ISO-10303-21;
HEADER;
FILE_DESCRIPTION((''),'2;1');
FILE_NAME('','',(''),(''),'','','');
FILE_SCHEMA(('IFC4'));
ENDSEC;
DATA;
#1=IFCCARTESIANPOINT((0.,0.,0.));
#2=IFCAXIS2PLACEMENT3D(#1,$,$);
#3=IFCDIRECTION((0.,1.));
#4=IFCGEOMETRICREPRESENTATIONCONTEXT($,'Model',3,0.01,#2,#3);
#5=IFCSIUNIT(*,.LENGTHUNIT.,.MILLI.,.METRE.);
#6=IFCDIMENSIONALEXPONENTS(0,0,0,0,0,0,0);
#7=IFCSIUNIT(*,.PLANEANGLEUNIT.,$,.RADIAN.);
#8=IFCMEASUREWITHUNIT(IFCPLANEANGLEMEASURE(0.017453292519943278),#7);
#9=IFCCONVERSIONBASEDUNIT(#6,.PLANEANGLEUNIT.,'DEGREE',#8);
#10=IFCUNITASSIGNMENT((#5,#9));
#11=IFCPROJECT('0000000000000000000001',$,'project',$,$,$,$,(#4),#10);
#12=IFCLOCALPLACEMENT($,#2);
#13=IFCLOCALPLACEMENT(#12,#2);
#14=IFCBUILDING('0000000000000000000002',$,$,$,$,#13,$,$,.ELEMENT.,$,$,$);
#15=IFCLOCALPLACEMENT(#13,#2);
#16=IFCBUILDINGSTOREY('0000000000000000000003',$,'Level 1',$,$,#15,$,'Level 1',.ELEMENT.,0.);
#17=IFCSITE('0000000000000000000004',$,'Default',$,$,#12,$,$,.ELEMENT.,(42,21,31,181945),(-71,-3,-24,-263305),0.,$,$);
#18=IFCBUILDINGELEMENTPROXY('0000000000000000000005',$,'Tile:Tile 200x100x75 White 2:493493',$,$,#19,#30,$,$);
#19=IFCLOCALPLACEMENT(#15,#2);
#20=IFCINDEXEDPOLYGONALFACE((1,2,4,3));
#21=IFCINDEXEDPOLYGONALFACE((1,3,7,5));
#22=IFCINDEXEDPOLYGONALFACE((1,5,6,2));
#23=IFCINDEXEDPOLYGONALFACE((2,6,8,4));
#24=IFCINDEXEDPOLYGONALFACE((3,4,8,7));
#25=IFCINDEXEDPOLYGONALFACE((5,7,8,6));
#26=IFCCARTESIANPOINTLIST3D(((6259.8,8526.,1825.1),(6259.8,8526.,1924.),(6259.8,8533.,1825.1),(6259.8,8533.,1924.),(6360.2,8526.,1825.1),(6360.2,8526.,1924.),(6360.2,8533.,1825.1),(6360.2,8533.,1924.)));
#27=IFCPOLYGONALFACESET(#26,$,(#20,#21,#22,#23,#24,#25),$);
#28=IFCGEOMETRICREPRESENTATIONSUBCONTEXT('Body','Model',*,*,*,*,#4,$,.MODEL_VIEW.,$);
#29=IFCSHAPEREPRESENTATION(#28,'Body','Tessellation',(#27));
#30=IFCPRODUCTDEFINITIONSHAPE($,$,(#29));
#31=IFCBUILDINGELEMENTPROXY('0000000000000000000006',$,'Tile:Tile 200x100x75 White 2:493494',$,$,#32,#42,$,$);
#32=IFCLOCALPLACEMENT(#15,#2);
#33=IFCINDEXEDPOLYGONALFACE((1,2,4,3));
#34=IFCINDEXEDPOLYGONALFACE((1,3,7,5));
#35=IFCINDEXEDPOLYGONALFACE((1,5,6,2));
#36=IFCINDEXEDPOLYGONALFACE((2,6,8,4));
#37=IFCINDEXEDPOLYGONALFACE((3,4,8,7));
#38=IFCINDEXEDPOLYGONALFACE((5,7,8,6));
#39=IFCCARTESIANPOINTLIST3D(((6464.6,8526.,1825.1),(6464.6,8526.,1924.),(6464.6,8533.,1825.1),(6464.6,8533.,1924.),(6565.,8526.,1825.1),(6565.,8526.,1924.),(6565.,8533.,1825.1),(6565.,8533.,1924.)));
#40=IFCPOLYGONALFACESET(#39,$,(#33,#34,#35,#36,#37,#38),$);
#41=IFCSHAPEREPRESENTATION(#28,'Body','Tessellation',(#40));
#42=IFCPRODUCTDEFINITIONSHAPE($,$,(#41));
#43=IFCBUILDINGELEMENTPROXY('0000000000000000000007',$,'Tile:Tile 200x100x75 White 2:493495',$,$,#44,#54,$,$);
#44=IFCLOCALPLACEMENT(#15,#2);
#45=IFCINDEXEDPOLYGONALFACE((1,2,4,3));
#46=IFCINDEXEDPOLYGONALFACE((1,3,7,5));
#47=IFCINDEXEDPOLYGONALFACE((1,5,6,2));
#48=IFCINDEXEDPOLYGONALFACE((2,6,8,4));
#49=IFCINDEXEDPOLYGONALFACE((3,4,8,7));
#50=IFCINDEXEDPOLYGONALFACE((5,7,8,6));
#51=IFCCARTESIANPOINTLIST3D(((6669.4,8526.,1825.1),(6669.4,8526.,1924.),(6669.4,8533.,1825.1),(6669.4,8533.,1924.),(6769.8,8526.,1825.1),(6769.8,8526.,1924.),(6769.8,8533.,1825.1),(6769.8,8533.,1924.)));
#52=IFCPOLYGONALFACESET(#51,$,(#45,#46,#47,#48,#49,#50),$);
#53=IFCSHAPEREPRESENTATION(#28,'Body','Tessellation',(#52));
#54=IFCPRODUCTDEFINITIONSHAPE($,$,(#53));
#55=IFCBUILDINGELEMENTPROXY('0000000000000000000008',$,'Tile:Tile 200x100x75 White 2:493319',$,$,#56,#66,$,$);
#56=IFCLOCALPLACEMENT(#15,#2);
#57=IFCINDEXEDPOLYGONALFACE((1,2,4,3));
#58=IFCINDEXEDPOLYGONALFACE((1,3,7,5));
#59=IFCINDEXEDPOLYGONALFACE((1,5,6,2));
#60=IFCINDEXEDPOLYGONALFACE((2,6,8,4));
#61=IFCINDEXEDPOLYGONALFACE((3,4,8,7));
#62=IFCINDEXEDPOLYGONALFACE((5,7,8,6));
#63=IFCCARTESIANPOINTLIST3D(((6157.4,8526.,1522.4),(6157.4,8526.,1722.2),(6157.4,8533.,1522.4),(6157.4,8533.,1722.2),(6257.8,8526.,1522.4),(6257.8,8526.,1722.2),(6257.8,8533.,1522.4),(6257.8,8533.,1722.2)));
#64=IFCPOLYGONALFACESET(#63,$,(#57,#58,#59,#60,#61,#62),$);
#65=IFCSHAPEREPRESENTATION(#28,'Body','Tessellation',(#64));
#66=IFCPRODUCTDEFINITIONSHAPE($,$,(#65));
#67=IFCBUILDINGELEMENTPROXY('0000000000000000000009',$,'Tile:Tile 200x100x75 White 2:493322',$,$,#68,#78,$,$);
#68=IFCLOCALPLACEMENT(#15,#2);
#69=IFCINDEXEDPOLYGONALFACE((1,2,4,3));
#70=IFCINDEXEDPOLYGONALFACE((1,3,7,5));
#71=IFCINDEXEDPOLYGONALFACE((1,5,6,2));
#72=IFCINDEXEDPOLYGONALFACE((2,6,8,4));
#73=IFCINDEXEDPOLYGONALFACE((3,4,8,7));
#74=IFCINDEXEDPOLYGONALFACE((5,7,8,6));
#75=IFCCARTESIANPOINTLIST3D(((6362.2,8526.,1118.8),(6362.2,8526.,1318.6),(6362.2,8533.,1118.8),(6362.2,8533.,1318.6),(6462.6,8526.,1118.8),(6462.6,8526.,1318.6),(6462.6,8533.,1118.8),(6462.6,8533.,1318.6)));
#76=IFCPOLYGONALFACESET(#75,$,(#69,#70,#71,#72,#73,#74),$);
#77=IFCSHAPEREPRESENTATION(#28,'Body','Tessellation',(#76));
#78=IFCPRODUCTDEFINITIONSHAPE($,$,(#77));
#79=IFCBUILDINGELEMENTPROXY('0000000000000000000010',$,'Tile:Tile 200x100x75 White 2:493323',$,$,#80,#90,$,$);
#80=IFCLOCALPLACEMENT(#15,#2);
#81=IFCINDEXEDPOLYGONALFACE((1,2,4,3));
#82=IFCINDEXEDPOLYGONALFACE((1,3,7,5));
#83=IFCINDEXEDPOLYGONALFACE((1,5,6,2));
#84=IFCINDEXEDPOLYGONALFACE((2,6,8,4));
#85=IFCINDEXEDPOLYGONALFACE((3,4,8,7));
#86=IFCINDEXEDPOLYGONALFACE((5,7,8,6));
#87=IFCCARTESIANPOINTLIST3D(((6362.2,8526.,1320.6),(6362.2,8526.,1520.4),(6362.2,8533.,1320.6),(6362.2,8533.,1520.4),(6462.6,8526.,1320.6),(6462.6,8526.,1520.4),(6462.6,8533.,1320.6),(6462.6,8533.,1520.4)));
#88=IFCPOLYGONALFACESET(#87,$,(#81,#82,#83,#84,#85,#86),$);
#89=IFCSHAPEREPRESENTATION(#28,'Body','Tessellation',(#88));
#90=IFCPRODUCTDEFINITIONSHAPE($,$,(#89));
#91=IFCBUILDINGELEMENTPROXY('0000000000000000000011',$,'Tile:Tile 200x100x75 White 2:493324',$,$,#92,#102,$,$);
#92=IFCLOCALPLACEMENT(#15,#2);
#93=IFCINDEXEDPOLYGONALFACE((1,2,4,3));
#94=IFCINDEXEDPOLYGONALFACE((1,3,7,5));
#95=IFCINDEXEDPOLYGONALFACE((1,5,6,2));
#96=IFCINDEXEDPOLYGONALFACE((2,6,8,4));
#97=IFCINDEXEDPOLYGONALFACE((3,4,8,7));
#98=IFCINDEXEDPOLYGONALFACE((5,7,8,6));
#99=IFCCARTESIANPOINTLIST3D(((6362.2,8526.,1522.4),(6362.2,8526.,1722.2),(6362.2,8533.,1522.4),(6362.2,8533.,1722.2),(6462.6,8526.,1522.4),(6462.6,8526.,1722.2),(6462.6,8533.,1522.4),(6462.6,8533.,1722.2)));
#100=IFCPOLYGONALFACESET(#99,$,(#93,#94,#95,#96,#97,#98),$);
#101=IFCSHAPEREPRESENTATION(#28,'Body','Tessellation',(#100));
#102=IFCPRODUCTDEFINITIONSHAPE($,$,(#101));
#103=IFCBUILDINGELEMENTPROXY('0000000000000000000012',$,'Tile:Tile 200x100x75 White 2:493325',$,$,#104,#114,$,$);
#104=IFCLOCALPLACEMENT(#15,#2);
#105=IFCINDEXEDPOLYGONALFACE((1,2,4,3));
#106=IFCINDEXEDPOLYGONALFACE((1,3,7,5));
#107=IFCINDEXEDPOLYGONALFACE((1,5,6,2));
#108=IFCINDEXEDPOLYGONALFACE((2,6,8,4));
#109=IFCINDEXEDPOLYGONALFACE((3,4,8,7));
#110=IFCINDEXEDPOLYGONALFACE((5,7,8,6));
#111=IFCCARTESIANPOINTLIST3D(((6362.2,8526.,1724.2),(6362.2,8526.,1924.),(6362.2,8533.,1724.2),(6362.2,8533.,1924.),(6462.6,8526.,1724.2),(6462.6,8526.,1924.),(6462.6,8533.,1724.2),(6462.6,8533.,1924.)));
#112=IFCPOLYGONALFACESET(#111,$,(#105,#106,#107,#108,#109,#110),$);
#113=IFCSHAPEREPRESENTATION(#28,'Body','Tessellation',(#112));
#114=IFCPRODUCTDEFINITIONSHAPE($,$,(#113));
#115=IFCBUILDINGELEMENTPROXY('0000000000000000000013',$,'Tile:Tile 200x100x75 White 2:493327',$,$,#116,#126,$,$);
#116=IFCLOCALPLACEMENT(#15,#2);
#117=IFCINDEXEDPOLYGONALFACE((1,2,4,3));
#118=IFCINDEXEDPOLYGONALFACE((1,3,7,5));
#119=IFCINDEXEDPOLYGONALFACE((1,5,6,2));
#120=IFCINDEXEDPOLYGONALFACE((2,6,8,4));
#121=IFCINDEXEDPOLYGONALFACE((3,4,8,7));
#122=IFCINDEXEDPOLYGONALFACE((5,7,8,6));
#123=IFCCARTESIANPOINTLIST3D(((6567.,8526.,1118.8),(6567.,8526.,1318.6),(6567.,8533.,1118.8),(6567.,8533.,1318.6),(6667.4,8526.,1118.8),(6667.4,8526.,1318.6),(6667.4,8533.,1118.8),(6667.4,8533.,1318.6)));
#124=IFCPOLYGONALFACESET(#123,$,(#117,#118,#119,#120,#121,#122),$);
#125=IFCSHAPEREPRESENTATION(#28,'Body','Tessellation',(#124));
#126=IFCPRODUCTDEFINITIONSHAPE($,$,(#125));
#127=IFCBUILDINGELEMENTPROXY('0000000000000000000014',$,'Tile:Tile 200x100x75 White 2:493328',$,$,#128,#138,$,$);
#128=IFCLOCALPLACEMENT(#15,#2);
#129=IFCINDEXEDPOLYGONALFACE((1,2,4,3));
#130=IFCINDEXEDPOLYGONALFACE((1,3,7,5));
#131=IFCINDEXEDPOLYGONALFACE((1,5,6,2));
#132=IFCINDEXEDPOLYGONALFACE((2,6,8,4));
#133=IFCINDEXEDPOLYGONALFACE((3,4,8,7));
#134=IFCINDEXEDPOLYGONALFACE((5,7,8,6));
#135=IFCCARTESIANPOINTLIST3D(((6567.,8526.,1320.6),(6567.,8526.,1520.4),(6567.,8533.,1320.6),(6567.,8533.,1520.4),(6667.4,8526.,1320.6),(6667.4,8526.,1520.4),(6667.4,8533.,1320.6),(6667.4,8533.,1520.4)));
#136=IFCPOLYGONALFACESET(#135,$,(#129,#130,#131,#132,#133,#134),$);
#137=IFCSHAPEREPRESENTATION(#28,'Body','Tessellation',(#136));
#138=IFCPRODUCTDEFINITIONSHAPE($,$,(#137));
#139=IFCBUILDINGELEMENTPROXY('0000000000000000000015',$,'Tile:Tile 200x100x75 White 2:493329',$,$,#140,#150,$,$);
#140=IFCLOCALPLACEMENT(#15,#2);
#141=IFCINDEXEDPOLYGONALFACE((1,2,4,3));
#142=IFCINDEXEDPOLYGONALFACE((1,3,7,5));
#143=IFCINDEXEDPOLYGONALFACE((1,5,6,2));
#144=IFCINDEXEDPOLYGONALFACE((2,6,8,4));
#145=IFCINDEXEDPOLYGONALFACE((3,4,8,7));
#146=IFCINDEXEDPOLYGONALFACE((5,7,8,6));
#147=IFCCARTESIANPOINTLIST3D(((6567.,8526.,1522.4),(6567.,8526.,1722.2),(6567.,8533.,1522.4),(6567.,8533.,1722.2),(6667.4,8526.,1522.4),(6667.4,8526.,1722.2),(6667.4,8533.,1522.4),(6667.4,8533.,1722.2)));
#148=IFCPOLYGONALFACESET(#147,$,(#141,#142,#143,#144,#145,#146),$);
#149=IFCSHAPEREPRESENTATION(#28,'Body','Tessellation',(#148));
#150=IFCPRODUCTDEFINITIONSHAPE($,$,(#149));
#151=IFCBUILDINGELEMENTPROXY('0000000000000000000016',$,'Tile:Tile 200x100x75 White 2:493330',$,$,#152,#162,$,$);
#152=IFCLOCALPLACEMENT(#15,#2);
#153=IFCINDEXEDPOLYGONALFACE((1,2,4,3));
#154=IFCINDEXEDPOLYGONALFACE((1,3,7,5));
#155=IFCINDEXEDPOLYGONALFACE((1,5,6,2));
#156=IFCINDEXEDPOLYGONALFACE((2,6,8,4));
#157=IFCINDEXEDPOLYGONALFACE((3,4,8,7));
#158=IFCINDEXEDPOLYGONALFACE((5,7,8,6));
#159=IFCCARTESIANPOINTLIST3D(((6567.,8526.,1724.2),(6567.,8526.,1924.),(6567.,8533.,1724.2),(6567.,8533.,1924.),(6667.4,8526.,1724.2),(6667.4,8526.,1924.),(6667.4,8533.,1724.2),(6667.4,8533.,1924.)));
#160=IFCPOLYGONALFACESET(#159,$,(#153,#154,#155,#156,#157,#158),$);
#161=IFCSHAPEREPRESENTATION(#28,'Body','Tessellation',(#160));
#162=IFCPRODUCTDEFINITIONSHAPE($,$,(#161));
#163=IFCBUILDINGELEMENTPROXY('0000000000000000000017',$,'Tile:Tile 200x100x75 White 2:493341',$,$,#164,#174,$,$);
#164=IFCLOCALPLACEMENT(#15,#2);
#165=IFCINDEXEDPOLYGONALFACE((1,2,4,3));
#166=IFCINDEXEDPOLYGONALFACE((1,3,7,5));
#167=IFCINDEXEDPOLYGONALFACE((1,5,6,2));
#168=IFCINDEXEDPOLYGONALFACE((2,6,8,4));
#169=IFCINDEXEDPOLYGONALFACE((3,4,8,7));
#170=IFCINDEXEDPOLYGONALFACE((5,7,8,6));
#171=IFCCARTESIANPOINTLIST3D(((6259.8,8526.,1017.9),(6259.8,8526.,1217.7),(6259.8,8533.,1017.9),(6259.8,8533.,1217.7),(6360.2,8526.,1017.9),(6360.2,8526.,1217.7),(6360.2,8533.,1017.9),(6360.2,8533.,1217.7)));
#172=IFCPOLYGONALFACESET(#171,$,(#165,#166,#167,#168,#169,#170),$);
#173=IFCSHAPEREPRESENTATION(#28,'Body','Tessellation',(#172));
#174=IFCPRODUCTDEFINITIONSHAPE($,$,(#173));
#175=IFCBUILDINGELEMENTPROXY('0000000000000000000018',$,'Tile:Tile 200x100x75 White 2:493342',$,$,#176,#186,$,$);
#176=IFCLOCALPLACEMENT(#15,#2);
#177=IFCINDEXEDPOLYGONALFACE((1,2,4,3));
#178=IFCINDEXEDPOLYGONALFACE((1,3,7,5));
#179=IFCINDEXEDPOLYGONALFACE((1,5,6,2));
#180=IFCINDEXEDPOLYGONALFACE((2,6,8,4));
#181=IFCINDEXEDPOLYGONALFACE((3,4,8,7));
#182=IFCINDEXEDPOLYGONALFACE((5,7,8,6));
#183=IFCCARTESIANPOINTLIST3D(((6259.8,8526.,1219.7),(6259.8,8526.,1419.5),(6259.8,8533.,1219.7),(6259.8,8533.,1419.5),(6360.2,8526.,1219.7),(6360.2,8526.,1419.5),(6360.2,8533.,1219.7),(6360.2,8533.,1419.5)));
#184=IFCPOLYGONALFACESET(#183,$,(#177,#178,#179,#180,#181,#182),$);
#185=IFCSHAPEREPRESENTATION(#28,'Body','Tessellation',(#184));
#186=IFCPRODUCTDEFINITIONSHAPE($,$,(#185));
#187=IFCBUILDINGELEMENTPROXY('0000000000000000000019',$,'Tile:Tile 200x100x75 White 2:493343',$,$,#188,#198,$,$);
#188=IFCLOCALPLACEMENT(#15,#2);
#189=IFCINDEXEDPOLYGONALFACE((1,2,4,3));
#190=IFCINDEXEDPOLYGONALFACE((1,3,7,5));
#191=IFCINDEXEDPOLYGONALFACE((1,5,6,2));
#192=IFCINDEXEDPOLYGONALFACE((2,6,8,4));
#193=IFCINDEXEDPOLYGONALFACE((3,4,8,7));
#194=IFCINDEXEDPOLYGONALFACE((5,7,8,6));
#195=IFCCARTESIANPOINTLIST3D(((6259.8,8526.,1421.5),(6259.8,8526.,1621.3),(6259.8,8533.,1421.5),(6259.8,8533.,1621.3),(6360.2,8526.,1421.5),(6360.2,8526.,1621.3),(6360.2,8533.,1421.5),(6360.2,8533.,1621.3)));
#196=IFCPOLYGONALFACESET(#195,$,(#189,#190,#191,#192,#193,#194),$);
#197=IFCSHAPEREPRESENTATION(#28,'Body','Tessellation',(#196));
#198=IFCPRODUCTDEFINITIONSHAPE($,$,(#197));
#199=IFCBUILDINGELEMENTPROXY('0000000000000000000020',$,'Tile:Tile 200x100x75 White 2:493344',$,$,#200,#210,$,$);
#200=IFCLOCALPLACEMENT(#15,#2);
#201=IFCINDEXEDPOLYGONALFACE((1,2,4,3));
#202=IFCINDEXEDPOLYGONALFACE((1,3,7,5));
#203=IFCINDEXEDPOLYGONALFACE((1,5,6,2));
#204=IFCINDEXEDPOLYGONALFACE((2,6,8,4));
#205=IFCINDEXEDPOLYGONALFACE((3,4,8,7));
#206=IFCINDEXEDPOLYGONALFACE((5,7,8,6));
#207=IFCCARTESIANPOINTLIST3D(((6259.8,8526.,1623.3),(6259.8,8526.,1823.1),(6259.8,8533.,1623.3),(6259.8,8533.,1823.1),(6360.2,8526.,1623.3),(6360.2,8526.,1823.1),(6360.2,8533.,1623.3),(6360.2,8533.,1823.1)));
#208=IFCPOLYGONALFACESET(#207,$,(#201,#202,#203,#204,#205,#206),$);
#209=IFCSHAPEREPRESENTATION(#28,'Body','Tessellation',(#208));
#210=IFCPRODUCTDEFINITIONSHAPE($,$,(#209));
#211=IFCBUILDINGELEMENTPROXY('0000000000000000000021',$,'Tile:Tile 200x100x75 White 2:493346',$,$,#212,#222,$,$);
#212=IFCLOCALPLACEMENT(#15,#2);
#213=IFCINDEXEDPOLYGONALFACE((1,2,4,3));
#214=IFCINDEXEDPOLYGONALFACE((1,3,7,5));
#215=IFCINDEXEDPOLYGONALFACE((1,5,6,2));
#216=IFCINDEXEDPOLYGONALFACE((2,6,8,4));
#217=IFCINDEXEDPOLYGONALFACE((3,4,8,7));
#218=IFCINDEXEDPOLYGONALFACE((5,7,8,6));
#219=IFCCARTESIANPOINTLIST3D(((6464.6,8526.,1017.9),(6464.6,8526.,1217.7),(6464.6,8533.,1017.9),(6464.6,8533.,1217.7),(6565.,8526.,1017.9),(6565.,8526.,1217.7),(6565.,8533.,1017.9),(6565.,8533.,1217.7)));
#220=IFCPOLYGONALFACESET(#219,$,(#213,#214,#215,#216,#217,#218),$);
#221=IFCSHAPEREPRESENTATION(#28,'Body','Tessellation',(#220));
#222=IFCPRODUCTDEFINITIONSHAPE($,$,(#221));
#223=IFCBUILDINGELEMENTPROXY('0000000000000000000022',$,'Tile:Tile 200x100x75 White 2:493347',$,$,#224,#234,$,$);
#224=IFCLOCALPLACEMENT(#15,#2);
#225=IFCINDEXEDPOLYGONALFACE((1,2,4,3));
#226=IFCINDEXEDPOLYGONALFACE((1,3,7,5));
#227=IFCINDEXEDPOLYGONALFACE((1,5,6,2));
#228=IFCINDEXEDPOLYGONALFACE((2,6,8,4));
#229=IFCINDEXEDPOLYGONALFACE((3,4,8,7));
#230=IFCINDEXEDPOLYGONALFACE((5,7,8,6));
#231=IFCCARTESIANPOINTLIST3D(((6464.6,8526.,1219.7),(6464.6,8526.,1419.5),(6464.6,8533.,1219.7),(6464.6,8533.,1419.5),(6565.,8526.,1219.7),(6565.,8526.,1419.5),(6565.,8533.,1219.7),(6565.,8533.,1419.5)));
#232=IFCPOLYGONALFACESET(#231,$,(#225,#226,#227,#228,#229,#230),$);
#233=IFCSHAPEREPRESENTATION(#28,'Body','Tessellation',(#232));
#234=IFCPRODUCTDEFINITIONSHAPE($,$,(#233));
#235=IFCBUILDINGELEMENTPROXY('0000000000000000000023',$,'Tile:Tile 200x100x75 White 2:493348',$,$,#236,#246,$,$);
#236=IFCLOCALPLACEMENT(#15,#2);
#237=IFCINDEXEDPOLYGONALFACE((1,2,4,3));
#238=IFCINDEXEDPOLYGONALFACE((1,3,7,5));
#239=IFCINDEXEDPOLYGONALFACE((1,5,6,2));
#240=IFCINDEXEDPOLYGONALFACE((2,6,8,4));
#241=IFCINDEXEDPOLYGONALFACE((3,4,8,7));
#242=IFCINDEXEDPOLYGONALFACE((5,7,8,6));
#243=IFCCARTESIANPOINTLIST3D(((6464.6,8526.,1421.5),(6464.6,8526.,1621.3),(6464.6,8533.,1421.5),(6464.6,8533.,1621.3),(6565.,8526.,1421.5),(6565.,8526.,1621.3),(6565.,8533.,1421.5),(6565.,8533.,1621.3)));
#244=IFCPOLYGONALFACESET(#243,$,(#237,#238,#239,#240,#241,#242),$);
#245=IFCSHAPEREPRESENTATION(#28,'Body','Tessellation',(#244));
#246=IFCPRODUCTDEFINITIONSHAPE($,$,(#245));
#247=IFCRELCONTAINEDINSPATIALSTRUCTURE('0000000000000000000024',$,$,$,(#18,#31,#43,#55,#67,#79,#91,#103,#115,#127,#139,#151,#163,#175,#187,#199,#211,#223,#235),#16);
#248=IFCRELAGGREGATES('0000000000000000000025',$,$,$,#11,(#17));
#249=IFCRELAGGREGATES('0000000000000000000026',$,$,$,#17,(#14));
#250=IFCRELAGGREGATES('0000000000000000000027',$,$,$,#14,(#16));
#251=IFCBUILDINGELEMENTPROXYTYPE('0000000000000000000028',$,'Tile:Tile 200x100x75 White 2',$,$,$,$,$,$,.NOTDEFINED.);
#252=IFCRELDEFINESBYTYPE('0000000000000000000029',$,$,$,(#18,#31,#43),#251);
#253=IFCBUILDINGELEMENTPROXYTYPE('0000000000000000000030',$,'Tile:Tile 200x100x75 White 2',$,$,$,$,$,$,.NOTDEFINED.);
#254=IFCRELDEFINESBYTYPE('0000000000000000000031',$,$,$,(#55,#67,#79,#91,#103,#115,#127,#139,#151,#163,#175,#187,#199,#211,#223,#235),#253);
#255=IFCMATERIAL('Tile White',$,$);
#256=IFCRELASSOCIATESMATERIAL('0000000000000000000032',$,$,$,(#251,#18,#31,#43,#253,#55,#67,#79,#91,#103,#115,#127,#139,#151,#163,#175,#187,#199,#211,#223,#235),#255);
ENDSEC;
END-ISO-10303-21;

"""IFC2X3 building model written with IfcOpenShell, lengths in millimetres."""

from ifc_helpers import new_model, entity, si_unit, converted_unit, direction, frame, frame_2d, origin, origin_2d_with_axis, place, context, subcontext, project, spatial, rectangle, extrude, source, transform, mapped, material, type_object, type_shapes, element, save


model = new_model("IFC2X3")

# Units and contexts
model_context = context("Model", 3, precision=0.01, world=origin(), true_north=direction((0.0, 1.0)))
body_context = subcontext(model_context, "Body", "Model", "MODEL_VIEW")
ifc_project = project(units=[si_unit("LENGTHUNIT", "METRE", prefix="MILLI"), converted_unit("PLANEANGLEUNIT", "DEGREE", entity("IfcPlaneAngleMeasure", 0.017453292519943278), si_unit("PLANEANGLEUNIT", "RADIAN"), dimensions=[0, 0, 0, 0, 0, 0, 0])], contexts=[model_context])

# Site, building, storey
site_placement = place(None, origin())
site = spatial("IfcSite", under=ifc_project, at=site_placement, Name="Default", CompositionType="ELEMENT", RefLatitude=(42, 21, 31, 181945), RefLongitude=(-71, -3, -24, -263305), RefElevation=0.0)
building_placement = place(site_placement, origin())
building = spatial("IfcBuilding", under=site, at=building_placement, CompositionType="ELEMENT")
storey_placement = place(building_placement, origin())
storey = spatial("IfcBuildingStorey", under=building, at=storey_placement, Name="Level 1", LongName="Level 1", CompositionType="ELEMENT", Elevation=0.0)

# Building element proxies
ifc_material = material(Name="Tile White")
building_element_proxy_type_1 = type_object("IfcBuildingElementProxyType", Name="Tile:Tile 200x100x75 White 2", PredefinedType="NOTDEFINED", material=ifc_material)
shared_shape_1 = source(origin(), body_context, "Body", "SweptSolid", [
    extrude(rectangle(XDim=98.9, YDim=100.4, at=origin_2d_with_axis()), frame((-50.2, -49.5, 0.0), z_axis=(0.0, 0.0, 1.0), x_axis=(0.0, -1.0, 0.0)), (0.0, 0.0, 1.0), 7.0),
])
type_shapes(building_element_proxy_type_1, [shared_shape_1])
for number, where, z_axis, x_axis, name in (
    (1, (6360.2, 8533.0, 1924.0), (0.0, -1.0, 0.0), (1.0, 0.0, 0.0), "Tile:Tile 200x100x75 White 2:493493"),
    (2, (6565.0, 8533.0, 1924.0), (0.0, -1.0, 0.0), (1.0, 0.0, 0.0), "Tile:Tile 200x100x75 White 2:493494"),
    (3, (6769.8, 8533.0, 1924.0), (0.0, -1.0, 0.0), (1.0, 0.0, 0.0), "Tile:Tile 200x100x75 White 2:493495"),
):
    element("IfcBuildingElementProxy", number, at=place(storey_placement, frame(where, z_axis=z_axis, x_axis=x_axis)), inside=storey, type_object=building_element_proxy_type_1, material=ifc_material, Name=name, context=body_context, shape_type="MappedRepresentation", body=[
        mapped(shared_shape_1, transform((0.0, 0.0, 0.0), scale=1.0)),
    ])
building_element_proxy_type_2 = type_object("IfcBuildingElementProxyType", Name="Tile:Tile 200x100x75 White 2", PredefinedType="NOTDEFINED", material=ifc_material)
shared_shape_2 = source(origin(), body_context, "Body", "SweptSolid", [
    extrude(rectangle(XDim=199.8, YDim=100.4, at=frame_2d((0.0, 0.0), x_axis=(1.0, 0.0))), frame((-50.2, -99.9, 0.0), z_axis=(0.0, 0.0, 1.0), x_axis=(0.0, -1.0, 0.0)), (0.0, 0.0, 1.0), 7.0),
])
type_shapes(building_element_proxy_type_2, [shared_shape_2])
for number, where, z_axis, x_axis, name in (
    (4, (6257.8, 8533.0, 1722.2), (0.0, -1.0, 0.0), (1.0, 0.0, 0.0), "Tile:Tile 200x100x75 White 2:493319"),
    (5, (6462.6, 8533.0, 1318.6), (0.0, -1.0, 0.0), (1.0, 0.0, 0.0), "Tile:Tile 200x100x75 White 2:493322"),
    (6, (6462.6, 8533.0, 1520.4), (0.0, -1.0, 0.0), (1.0, 0.0, 0.0), "Tile:Tile 200x100x75 White 2:493323"),
    (7, (6462.6, 8533.0, 1722.2), (0.0, -1.0, 0.0), (1.0, 0.0, 0.0), "Tile:Tile 200x100x75 White 2:493324"),
    (8, (6462.6, 8533.0, 1924.0), (0.0, -1.0, 0.0), (1.0, 0.0, 0.0), "Tile:Tile 200x100x75 White 2:493325"),
    (9, (6667.4, 8533.0, 1318.6), (0.0, -1.0, 0.0), (1.0, 0.0, 0.0), "Tile:Tile 200x100x75 White 2:493327"),
    (10, (6667.4, 8533.0, 1520.4), (0.0, -1.0, 0.0), (1.0, 0.0, 0.0), "Tile:Tile 200x100x75 White 2:493328"),
    (11, (6667.4, 8533.0, 1722.2), (0.0, -1.0, 0.0), (1.0, 0.0, 0.0), "Tile:Tile 200x100x75 White 2:493329"),
    (12, (6667.4, 8533.0, 1924.0), (0.0, -1.0, 0.0), (1.0, 0.0, 0.0), "Tile:Tile 200x100x75 White 2:493330"),
    (13, (6360.2, 8533.0, 1217.7), (0.0, -1.0, 0.0), (1.0, 0.0, 0.0), "Tile:Tile 200x100x75 White 2:493341"),
    (14, (6360.2, 8533.0, 1419.5), (0.0, -1.0, 0.0), (1.0, 0.0, 0.0), "Tile:Tile 200x100x75 White 2:493342"),
    (15, (6360.2, 8533.0, 1621.3), (0.0, -1.0, 0.0), (1.0, 0.0, 0.0), "Tile:Tile 200x100x75 White 2:493343"),
    (16, (6360.2, 8533.0, 1823.1), (0.0, -1.0, 0.0), (1.0, 0.0, 0.0), "Tile:Tile 200x100x75 White 2:493344"),
    (17, (6565.0, 8533.0, 1217.7), (0.0, -1.0, 0.0), (1.0, 0.0, 0.0), "Tile:Tile 200x100x75 White 2:493346"),
    (18, (6565.0, 8533.0, 1419.5), (0.0, -1.0, 0.0), (1.0, 0.0, 0.0), "Tile:Tile 200x100x75 White 2:493347"),
    (19, (6565.0, 8533.0, 1621.3), (0.0, -1.0, 0.0), (1.0, 0.0, 0.0), "Tile:Tile 200x100x75 White 2:493348"),
):
    element("IfcBuildingElementProxy", number, at=place(storey_placement, frame(where, z_axis=z_axis, x_axis=x_axis)), inside=storey, type_object=building_element_proxy_type_2, material=ifc_material, Name=name, context=body_context, shape_type="MappedRepresentation", body=[
        mapped(shared_shape_2, transform((0.0, 0.0, 0.0), scale=1.0)),
    ])

save(model, "model.ifc")
